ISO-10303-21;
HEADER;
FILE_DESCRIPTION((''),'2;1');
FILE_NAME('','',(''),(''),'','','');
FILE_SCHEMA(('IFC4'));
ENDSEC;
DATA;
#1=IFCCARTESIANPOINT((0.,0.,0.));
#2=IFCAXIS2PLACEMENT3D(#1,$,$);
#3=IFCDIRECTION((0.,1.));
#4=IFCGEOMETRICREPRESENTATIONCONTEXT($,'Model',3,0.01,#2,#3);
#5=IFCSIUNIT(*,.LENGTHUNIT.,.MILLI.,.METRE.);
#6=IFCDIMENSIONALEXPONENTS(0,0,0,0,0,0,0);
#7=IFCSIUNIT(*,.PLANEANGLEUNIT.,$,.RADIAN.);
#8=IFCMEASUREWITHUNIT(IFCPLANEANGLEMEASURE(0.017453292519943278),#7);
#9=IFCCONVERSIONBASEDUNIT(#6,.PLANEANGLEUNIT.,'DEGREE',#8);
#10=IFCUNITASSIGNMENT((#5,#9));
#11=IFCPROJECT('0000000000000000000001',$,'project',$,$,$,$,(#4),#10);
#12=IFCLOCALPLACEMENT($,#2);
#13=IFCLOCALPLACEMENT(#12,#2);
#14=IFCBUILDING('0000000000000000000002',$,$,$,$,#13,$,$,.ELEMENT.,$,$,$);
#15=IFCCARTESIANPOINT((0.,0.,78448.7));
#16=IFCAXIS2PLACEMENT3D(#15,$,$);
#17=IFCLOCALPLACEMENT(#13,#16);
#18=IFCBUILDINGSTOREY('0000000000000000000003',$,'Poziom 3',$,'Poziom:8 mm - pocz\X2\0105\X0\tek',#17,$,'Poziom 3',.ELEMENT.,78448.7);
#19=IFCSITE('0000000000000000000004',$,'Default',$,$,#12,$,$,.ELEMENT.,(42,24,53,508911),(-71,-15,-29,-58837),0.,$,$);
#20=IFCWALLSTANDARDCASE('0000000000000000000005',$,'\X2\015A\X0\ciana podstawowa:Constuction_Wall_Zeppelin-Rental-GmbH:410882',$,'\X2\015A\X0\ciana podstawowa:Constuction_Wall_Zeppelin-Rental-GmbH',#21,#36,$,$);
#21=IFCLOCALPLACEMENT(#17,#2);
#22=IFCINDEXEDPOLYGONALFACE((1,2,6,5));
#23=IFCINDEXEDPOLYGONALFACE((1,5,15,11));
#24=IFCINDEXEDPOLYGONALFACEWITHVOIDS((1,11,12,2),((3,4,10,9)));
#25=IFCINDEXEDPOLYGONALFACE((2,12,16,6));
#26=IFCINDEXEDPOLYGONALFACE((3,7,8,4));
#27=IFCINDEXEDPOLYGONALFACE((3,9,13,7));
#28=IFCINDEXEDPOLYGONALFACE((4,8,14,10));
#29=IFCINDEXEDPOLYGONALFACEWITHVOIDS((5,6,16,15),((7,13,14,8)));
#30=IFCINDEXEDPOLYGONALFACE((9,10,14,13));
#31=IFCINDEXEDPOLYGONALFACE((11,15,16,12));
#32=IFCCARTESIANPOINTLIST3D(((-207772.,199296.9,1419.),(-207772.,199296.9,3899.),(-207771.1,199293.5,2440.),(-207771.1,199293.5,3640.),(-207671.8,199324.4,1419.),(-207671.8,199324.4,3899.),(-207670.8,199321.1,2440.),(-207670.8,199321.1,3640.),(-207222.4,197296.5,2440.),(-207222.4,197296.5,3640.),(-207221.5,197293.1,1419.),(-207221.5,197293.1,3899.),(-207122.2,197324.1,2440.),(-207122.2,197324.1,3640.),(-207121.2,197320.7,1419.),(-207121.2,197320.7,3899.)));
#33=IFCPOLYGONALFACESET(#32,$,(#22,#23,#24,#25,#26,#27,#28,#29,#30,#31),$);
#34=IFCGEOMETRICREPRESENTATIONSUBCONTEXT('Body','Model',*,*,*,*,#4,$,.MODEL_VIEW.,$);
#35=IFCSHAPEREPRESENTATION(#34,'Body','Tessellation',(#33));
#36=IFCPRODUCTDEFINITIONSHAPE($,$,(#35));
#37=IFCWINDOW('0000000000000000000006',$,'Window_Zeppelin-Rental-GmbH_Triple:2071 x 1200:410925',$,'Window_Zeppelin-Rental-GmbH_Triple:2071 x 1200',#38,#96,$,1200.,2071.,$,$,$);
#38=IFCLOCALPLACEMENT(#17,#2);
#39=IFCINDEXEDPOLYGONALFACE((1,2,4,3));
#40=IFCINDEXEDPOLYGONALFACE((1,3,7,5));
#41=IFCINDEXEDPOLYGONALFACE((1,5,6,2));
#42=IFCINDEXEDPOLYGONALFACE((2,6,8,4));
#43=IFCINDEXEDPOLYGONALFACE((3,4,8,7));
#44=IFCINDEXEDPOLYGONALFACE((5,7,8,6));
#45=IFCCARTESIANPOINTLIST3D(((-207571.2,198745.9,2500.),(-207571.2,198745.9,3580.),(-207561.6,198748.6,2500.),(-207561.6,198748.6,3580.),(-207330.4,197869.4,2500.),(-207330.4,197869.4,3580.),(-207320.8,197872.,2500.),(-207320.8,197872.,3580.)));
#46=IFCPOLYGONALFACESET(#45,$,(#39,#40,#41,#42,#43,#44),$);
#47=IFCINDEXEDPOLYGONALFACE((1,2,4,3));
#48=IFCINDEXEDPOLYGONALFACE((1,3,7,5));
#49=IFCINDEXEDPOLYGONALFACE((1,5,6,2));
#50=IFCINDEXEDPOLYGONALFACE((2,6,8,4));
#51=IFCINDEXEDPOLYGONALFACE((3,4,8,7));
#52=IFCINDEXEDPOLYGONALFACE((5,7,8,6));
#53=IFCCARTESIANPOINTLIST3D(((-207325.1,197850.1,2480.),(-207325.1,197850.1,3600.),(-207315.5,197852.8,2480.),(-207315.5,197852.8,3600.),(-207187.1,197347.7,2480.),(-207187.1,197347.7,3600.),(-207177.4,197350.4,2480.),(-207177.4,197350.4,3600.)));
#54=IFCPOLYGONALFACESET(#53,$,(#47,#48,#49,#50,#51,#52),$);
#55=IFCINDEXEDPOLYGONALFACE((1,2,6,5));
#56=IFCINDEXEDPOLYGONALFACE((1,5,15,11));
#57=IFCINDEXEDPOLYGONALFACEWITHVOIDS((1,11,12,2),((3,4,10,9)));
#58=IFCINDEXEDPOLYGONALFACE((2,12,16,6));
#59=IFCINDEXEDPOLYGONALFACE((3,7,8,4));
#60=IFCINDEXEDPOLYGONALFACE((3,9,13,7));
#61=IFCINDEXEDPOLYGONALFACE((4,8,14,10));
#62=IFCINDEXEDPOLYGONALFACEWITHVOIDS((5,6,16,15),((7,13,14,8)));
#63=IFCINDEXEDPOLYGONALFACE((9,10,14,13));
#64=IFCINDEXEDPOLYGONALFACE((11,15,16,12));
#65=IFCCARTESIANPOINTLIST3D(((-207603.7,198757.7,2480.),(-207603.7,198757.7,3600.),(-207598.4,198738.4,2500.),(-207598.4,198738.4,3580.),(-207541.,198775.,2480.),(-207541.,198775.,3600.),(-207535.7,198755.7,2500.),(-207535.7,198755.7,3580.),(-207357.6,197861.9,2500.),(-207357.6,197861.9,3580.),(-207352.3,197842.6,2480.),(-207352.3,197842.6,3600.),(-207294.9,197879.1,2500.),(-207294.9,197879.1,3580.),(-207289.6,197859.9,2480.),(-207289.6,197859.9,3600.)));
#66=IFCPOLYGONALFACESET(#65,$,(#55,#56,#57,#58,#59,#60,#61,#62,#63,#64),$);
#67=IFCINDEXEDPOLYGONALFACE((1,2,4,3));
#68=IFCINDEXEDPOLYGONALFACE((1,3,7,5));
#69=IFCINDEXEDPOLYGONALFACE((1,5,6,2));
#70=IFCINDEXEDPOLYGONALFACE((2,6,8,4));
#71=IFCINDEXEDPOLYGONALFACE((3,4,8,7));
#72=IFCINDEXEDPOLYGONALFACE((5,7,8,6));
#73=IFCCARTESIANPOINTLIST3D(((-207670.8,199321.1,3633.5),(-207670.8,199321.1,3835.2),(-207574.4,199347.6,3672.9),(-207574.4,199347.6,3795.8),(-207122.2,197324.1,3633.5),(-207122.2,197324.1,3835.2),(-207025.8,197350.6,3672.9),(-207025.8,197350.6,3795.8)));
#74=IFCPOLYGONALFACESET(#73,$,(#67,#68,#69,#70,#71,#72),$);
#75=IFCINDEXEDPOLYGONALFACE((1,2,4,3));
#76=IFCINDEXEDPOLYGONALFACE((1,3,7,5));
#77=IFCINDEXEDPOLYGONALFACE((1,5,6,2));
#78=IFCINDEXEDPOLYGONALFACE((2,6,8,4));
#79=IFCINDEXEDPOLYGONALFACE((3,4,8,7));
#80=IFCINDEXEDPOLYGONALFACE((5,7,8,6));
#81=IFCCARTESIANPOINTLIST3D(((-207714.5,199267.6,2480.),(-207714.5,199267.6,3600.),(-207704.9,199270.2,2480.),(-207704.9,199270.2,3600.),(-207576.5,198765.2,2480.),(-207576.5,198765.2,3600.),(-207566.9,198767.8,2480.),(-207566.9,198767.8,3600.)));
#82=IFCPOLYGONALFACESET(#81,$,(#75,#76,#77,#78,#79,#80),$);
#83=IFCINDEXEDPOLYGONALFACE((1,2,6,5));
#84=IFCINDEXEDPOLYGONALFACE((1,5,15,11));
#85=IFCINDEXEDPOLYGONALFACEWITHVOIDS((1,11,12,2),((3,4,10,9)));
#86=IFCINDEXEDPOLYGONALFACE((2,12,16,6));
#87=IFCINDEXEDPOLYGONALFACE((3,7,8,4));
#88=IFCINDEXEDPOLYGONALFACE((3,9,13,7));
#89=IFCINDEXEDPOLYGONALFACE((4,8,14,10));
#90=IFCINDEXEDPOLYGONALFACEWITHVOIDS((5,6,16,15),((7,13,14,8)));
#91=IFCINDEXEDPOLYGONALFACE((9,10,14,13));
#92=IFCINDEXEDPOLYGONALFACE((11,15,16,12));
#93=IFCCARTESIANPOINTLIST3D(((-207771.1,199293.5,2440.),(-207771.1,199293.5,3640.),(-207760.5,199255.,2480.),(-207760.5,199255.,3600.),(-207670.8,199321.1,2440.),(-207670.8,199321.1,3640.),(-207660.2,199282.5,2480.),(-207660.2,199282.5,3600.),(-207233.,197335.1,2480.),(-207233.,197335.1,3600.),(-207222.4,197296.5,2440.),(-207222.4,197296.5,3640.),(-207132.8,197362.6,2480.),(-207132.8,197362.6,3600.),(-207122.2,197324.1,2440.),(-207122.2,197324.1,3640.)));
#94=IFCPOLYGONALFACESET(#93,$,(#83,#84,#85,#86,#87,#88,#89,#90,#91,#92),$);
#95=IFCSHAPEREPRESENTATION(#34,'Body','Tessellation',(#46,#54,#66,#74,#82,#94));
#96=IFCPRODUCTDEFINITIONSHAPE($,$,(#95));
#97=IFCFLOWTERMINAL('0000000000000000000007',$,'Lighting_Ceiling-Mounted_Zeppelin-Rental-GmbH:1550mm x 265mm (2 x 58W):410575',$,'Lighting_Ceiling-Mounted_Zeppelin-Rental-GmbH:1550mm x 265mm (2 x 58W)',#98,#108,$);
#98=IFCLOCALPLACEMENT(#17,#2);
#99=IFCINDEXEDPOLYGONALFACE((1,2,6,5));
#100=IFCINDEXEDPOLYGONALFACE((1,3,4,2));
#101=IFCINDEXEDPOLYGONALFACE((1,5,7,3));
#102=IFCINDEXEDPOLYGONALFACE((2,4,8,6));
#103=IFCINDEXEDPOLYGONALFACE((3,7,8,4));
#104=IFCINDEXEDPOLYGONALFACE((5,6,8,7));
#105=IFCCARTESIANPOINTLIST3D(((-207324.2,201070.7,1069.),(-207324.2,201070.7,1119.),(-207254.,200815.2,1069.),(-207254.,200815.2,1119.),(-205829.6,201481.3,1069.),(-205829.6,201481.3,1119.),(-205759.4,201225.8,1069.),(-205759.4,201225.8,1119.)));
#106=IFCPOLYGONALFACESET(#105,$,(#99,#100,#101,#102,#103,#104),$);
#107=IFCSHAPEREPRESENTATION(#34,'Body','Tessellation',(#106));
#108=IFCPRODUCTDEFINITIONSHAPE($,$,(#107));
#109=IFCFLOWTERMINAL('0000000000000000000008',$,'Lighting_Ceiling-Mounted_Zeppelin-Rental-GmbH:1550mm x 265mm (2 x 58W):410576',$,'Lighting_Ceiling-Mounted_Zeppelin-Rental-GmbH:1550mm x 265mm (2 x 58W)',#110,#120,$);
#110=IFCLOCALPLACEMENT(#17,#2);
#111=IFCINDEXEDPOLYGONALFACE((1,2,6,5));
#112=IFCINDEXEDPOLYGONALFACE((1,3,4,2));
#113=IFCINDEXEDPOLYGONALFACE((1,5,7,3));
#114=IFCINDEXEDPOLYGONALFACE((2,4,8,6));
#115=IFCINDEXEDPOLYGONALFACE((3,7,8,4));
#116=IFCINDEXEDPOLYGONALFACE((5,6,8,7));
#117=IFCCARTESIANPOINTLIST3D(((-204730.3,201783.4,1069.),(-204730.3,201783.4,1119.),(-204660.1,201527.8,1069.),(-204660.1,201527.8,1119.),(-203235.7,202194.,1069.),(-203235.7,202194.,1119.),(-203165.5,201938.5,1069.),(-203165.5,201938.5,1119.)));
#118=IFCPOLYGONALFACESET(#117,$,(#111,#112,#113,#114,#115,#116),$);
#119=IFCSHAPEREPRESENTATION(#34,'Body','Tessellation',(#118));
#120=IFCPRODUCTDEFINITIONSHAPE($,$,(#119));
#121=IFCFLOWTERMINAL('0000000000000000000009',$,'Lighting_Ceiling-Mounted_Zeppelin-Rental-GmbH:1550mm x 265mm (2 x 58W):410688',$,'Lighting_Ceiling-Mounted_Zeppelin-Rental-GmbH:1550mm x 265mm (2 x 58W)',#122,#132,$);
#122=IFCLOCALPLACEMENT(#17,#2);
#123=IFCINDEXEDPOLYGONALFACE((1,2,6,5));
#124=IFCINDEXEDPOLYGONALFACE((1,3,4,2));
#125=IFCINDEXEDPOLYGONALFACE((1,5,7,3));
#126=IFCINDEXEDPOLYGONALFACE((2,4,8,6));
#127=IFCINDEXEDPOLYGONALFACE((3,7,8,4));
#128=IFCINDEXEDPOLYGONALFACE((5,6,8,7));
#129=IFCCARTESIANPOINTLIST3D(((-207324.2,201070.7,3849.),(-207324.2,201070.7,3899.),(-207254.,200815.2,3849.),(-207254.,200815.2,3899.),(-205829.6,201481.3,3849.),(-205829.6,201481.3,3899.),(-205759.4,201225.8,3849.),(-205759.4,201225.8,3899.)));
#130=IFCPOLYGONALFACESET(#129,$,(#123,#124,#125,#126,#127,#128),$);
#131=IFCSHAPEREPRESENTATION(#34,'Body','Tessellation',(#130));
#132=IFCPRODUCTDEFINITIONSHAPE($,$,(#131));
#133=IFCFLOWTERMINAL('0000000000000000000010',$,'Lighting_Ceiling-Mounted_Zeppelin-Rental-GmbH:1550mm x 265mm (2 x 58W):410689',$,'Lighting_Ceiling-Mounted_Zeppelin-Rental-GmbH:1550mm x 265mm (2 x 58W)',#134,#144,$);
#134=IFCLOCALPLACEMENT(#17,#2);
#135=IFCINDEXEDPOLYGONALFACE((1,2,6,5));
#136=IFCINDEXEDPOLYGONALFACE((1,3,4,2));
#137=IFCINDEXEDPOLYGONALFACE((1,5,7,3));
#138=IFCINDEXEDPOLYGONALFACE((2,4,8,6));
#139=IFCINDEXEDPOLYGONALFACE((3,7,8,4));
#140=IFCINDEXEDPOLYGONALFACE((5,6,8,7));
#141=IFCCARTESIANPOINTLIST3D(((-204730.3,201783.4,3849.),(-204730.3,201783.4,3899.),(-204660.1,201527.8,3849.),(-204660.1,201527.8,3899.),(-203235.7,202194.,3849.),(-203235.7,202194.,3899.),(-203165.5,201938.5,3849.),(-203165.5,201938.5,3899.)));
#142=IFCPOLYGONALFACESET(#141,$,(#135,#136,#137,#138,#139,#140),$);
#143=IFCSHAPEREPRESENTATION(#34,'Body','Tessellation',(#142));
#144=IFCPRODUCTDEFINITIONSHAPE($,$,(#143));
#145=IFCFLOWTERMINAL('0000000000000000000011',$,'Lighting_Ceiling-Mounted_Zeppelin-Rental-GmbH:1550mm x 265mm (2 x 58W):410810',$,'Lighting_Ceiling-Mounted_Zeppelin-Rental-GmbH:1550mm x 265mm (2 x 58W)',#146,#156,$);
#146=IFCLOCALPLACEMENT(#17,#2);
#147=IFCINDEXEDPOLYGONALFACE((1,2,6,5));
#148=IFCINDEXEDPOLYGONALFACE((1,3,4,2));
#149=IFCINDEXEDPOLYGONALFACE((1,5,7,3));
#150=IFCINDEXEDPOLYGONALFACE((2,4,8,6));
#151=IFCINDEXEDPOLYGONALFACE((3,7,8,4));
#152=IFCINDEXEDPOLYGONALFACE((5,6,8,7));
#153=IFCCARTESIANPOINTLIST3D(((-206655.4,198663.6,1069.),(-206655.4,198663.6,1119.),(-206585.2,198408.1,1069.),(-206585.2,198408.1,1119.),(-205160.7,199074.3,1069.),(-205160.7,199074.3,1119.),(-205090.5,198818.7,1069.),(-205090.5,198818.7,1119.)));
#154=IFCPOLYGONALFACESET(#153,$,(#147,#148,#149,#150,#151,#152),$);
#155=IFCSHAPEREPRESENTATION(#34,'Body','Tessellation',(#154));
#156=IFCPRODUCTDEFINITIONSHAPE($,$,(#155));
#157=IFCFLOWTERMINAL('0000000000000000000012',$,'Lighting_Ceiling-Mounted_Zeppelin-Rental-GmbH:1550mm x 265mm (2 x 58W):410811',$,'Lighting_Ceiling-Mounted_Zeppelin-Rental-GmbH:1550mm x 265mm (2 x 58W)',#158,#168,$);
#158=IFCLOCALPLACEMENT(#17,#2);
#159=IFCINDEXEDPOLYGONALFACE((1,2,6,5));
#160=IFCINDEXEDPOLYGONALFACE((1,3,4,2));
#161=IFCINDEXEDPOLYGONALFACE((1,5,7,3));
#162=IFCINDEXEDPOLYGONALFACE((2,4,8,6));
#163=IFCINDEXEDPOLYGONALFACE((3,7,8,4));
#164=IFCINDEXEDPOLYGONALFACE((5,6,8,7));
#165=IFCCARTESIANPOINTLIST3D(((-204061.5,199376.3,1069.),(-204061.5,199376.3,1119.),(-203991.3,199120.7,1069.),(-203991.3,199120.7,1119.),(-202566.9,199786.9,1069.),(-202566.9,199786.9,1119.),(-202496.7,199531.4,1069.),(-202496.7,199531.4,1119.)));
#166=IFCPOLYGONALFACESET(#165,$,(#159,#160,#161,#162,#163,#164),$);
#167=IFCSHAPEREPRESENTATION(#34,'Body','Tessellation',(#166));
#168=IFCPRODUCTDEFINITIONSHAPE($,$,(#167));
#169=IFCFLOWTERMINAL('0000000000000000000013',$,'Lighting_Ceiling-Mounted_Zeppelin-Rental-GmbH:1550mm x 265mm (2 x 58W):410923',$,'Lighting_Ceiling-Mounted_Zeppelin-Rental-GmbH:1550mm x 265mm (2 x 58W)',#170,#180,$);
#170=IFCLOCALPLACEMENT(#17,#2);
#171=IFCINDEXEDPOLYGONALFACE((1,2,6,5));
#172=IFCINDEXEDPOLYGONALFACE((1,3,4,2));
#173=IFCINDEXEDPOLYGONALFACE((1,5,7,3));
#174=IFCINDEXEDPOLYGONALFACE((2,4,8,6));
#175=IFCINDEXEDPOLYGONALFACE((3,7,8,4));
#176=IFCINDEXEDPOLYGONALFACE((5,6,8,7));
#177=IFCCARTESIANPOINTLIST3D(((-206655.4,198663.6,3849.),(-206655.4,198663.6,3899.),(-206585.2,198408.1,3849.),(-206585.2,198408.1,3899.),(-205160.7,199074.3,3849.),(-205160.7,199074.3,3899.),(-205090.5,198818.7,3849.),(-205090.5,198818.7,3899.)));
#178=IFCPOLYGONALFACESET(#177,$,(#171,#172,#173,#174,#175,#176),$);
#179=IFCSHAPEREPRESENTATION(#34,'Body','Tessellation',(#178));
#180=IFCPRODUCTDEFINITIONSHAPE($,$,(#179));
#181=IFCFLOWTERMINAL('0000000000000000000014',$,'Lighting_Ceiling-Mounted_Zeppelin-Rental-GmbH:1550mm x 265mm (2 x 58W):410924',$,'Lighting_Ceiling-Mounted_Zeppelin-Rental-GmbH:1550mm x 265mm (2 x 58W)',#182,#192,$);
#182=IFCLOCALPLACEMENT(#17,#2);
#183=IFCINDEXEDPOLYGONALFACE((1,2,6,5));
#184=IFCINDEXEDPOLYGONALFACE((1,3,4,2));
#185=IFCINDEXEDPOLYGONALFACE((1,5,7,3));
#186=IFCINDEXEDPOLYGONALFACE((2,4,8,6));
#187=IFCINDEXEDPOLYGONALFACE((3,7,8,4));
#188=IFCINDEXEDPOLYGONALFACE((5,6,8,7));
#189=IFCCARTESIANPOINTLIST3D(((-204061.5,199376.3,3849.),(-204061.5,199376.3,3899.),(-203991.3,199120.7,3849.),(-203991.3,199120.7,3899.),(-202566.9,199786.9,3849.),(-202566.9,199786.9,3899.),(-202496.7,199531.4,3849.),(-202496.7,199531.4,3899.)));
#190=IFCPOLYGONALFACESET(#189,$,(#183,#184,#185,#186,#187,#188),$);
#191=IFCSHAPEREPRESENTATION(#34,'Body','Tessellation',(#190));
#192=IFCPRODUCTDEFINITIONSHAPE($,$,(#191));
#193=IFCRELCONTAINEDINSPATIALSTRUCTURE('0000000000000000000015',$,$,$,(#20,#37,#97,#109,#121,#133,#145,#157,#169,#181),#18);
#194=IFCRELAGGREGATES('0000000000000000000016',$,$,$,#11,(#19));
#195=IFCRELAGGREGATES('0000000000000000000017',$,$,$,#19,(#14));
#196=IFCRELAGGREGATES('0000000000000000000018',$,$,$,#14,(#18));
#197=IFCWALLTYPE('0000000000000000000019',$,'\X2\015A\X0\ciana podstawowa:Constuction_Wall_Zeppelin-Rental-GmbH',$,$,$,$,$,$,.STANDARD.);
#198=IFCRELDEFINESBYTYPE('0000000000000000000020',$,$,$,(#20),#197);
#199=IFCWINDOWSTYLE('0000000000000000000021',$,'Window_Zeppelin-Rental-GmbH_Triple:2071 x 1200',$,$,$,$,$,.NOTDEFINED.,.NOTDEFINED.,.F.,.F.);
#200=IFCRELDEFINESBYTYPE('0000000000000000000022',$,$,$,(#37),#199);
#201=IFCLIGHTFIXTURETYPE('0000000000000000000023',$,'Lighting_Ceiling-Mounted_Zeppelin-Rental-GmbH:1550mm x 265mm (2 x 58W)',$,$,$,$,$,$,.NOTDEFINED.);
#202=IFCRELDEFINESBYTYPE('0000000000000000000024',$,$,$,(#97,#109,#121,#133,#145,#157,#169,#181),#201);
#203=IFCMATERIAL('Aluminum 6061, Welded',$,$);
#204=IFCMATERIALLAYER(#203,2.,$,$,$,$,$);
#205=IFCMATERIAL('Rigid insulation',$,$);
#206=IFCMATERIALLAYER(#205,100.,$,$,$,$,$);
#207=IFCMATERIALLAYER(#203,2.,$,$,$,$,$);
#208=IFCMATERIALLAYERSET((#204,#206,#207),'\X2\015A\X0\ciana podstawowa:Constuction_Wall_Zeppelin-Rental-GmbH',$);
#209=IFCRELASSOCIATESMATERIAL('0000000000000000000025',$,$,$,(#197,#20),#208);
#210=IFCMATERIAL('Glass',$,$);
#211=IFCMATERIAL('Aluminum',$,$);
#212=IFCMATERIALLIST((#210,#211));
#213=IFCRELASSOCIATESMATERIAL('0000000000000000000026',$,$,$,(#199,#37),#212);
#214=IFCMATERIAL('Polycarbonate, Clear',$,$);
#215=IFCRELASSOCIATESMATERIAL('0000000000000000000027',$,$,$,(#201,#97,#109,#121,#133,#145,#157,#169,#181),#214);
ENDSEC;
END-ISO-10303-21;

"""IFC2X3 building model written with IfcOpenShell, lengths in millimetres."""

from ifc_helpers import new_model, entity, si_unit, converted_unit, direction, frame, frame_2d, origin, origin_2d_with_axis, place, context, subcontext, project, spatial, polyline, rectangle, outline, extrude, source, transform, mapped, material, material_list, layer, layer_set, layer_usage, type_object, type_shapes, element, fill, save


model = new_model("IFC2X3")

# Units and contexts
model_context = context("Model", 3, precision=0.01, world=origin(), true_north=direction((0.0, 1.0)))
body_context = subcontext(model_context, "Body", "Model", "MODEL_VIEW")
ifc_project = project(units=[si_unit("LENGTHUNIT", "METRE", prefix="MILLI"), converted_unit("PLANEANGLEUNIT", "DEGREE", entity("IfcPlaneAngleMeasure", 0.017453292519943278), si_unit("PLANEANGLEUNIT", "RADIAN"), dimensions=[0, 0, 0, 0, 0, 0, 0])], contexts=[model_context])

# Site, building, storey
site_placement = place(None, origin())
site = spatial("IfcSite", under=ifc_project, at=site_placement, Name="Default", CompositionType="ELEMENT", RefLatitude=(42, 24, 53, 508911), RefLongitude=(-71, -15, -29, -58837), RefElevation=0.0)
building_placement = place(site_placement, origin())
building = spatial("IfcBuilding", under=site, at=building_placement, CompositionType="ELEMENT")
storey_placement = place(building_placement, frame((0.0, 0.0, 78448.7)))
storey = spatial("IfcBuildingStorey", under=building, at=storey_placement, Name="Poziom 3", ObjectType="Poziom:8 mm - początek", LongName="Poziom 3", CompositionType="ELEMENT", Elevation=78448.7)

# Shared definitions
ifc_material_1 = material(Name="Aluminum 6061, Welded")
ifc_layer_1 = layer(ifc_material_1, 2.0)
ifc_material_2 = material(Name="Rigid insulation")
ifc_layer_2 = layer(ifc_material_2, 100.0)
ifc_layer_3 = layer(ifc_material_1, 2.0)
ifc_layer_set = layer_set([ifc_layer_1, ifc_layer_2, ifc_layer_3], Name="Ściana podstawowa:Constuction_Wall_Zeppelin-Rental-GmbH")
wall_type_1 = type_object("IfcWallType", Name="Ściana podstawowa:Constuction_Wall_Zeppelin-Rental-GmbH", PredefinedType="STANDARD", material=ifc_layer_set)

# Shared definitions
ifc_material_3 = material(Name="Glass")
ifc_material_4 = material(Name="Aluminum")
ifc_material_list = material_list([ifc_material_3, ifc_material_4])
window_style = type_object("IfcWindowStyle", Name="Window_Zeppelin-Rental-GmbH_Triple:2071 x 1200", ConstructionType="NOTDEFINED", OperationType="NOTDEFINED", ParameterTakesPrecedence=False, Sizeable=False, material=ifc_material_list)
shared_shape_1 = source(origin(), body_context, "Body", "SweptSolid", [
    extrude(rectangle(XDim=10.0, YDim=909.0, at=origin_2d_with_axis()), frame((1035.5, 52.7, 60.0), z_axis=(0.0, 0.0, 1.0), x_axis=(0.0, -1.0, 0.0)), (0.0, 0.0, 1.0), 1080.0),
    extrude(rectangle(XDim=521.0, YDim=10.0, at=frame_2d((0.0, 0.0), x_axis=(1.0, 0.0))), frame((300.5, 52.7, 40.0), z_axis=(0.0, 0.0, 1.0), x_axis=(-1.0, 0.0, 0.0)), (0.0, 0.0, 1.0), 1120.0),
    extrude(outline(polyline([(-474.5, -560.0), (474.5, -560.0), (474.5, 560.0), (-474.5, 560.0), (-474.5, -560.0)]), holes=[polyline([(-454.5, 540.0), (454.5, 540.0), (454.5, -540.0), (-454.5, -540.0), (-454.5, 540.0)])]), frame((1035.5, 85.8, 600.0), z_axis=(0.0, -1.0, 0.0), x_axis=(1.0, 0.0, 0.0)), (0.0, 0.0, 1.0), 65.0),
    extrude(outline(polyline([(-24.0, -75.5), (83.5, -75.5), (9.6, 112.1), (-69.0, 38.9), (-24.0, -75.5)])), frame((2071.0, -48.7, 1294.4), z_axis=(-1.0, 0.0, 0.0), x_axis=(0.0, 0.930458, 0.366398)), (0.0, 0.0, 1.0), 2071.0),
    extrude(rectangle(XDim=10.0, YDim=521.0, at=frame_2d((0.0, 0.0), x_axis=(1.0, 0.0))), frame((1770.5, 52.7, 40.0), z_axis=(0.0, 0.0, 1.0), x_axis=(0.0, -1.0, 0.0)), (0.0, 0.0, 1.0), 1120.0),
    extrude(outline(polyline([(-1035.5, -600.0), (1035.5, -600.0), (1035.5, 600.0), (-1035.5, 600.0), (-1035.5, -600.0)]), holes=[polyline([(-995.5, 560.0), (995.5, 560.0), (995.5, -560.0), (-995.5, -560.0), (-995.5, 560.0)])]), frame((1035.5, 105.3, 600.0), z_axis=(0.0, -1.0, 0.0), x_axis=(1.0, 0.0, 0.0)), (0.0, 0.0, 1.0), 104.0),
])
type_shapes(window_style, [shared_shape_1])

# Wall, opening, window
ifc_layer_usage_1 = layer_usage(ifc_layer_set, "AXIS2", "NEGATIVE", 52.0)
wall_1_placement = place(storey_placement, frame((-207171.4, 197306.9, 1419.0), z_axis=(0.0, 0.0, 1.0), x_axis=(-0.264931, 0.964267, 0.0)))
wall_1 = element("IfcWallStandardCase", 1, at=wall_1_placement, inside=storey, type_object=wall_type_1, material=ifc_layer_usage_1, Name="Ściana podstawowa:Constuction_Wall_Zeppelin-Rental-GmbH:410882", ObjectType="Ściana podstawowa:Constuction_Wall_Zeppelin-Rental-GmbH", context=body_context, shape_type="SweptSolid", body=[
    extrude(rectangle(XDim=2078.0, YDim=104.0, at=frame_2d((1039.0, 0.0), x_axis=(-1.0, 0.0))), origin(), (0.0, 0.0, 1.0), 2480.0),
])
opening_1_placement = place(wall_1_placement, frame((3.5, -52.0, 1021.0)))
opening_1 = element("IfcOpeningElement", 2, at=opening_1_placement, cuts=wall_1, ObjectType="Opening", context=body_context, shape_type="SweptSolid", body=[
    extrude(rectangle(XDim=1200.0, YDim=2071.0, at=frame_2d((600.0, 1035.5), x_axis=(1.0, 0.0))), frame((0.0, 0.0, 0.0), z_axis=(0.0, 1.0, 0.0), x_axis=(0.0, 0.0, 1.0)), (0.0, 0.0, 1.0), 104.0),
])
window_1_placement = place(opening_1_placement, frame((0.0, -1.3, 0.0)))
window_1 = element("IfcWindow", 3, at=window_1_placement, inside=storey, type_object=window_style, material=ifc_material_list, Name="Window_Zeppelin-Rental-GmbH_Triple:2071 x 1200:410925", ObjectType="Window_Zeppelin-Rental-GmbH_Triple:2071 x 1200", OverallHeight=1200.0, OverallWidth=2071.0, context=body_context, shape_type="MappedRepresentation", body=[
    mapped(shared_shape_1, transform((0.0, 0.0, 0.0), scale=1.0)),
])
fill(opening_1, window_1)

# Flow terminals
ifc_material_5 = material(Name="Polycarbonate, Clear")
light_fixture_type = type_object("IfcLightFixtureType", Name="Lighting_Ceiling-Mounted_Zeppelin-Rental-GmbH:1550mm x 265mm (2 x 58W)", PredefinedType="NOTDEFINED", material=ifc_material_5)
shared_shape_2 = source(origin(), body_context, "Body", "SweptSolid", [
    extrude(rectangle(XDim=1550.0, YDim=265.0, at=origin_2d_with_axis()), frame((0.0, 0.0, 0.0), z_axis=(0.0, 0.0, 1.0), x_axis=(-1.0, 0.0, 0.0)), (0.0, 0.0, 1.0), 50.0),
])
type_shapes(light_fixture_type, [shared_shape_2])
for number, where, z_axis, x_axis, name in (
    (4, (-206541.8, 201148.3, 1119.0), (0.0, 0.0, -1.0), (-0.964267, -0.264931, 0.0), "Lighting_Ceiling-Mounted_Zeppelin-Rental-GmbH:1550mm x 265mm (2 x 58W):410575"),
    (5, (-203947.9, 201860.9, 1119.0), (0.0, 0.0, -1.0), (-0.964267, -0.264931, 0.0), "Lighting_Ceiling-Mounted_Zeppelin-Rental-GmbH:1550mm x 265mm (2 x 58W):410576"),
    (6, (-206541.8, 201148.3, 3899.0), (0.0, 0.0, -1.0), (-0.964267, -0.264931, 0.0), "Lighting_Ceiling-Mounted_Zeppelin-Rental-GmbH:1550mm x 265mm (2 x 58W):410688"),
    (7, (-203947.9, 201860.9, 3899.0), (0.0, 0.0, -1.0), (-0.964267, -0.264931, 0.0), "Lighting_Ceiling-Mounted_Zeppelin-Rental-GmbH:1550mm x 265mm (2 x 58W):410689"),
    (8, (-205872.9, 198741.2, 1119.0), (0.0, 0.0, -1.0), (-0.964267, -0.264931, 0.0), "Lighting_Ceiling-Mounted_Zeppelin-Rental-GmbH:1550mm x 265mm (2 x 58W):410810"),
    (9, (-203279.1, 199453.8, 1119.0), (0.0, 0.0, -1.0), (-0.964267, -0.264931, 0.0), "Lighting_Ceiling-Mounted_Zeppelin-Rental-GmbH:1550mm x 265mm (2 x 58W):410811"),
    (10, (-205872.9, 198741.2, 3899.0), (0.0, 0.0, -1.0), (-0.964267, -0.264931, 0.0), "Lighting_Ceiling-Mounted_Zeppelin-Rental-GmbH:1550mm x 265mm (2 x 58W):410923"),
    (11, (-203279.1, 199453.8, 3899.0), (0.0, 0.0, -1.0), (-0.964267, -0.264931, 0.0), "Lighting_Ceiling-Mounted_Zeppelin-Rental-GmbH:1550mm x 265mm (2 x 58W):410924"),
):
    element("IfcFlowTerminal", number, at=place(storey_placement, frame(where, z_axis=z_axis, x_axis=x_axis)), inside=storey, type_object=light_fixture_type, material=ifc_material_5, Name=name, ObjectType="Lighting_Ceiling-Mounted_Zeppelin-Rental-GmbH:1550mm x 265mm (2 x 58W)", context=body_context, shape_type="MappedRepresentation", body=[
        mapped(shared_shape_2, transform((0.0, 0.0, 0.0), scale=1.0)),
    ])

save(model, "model.ifc")
